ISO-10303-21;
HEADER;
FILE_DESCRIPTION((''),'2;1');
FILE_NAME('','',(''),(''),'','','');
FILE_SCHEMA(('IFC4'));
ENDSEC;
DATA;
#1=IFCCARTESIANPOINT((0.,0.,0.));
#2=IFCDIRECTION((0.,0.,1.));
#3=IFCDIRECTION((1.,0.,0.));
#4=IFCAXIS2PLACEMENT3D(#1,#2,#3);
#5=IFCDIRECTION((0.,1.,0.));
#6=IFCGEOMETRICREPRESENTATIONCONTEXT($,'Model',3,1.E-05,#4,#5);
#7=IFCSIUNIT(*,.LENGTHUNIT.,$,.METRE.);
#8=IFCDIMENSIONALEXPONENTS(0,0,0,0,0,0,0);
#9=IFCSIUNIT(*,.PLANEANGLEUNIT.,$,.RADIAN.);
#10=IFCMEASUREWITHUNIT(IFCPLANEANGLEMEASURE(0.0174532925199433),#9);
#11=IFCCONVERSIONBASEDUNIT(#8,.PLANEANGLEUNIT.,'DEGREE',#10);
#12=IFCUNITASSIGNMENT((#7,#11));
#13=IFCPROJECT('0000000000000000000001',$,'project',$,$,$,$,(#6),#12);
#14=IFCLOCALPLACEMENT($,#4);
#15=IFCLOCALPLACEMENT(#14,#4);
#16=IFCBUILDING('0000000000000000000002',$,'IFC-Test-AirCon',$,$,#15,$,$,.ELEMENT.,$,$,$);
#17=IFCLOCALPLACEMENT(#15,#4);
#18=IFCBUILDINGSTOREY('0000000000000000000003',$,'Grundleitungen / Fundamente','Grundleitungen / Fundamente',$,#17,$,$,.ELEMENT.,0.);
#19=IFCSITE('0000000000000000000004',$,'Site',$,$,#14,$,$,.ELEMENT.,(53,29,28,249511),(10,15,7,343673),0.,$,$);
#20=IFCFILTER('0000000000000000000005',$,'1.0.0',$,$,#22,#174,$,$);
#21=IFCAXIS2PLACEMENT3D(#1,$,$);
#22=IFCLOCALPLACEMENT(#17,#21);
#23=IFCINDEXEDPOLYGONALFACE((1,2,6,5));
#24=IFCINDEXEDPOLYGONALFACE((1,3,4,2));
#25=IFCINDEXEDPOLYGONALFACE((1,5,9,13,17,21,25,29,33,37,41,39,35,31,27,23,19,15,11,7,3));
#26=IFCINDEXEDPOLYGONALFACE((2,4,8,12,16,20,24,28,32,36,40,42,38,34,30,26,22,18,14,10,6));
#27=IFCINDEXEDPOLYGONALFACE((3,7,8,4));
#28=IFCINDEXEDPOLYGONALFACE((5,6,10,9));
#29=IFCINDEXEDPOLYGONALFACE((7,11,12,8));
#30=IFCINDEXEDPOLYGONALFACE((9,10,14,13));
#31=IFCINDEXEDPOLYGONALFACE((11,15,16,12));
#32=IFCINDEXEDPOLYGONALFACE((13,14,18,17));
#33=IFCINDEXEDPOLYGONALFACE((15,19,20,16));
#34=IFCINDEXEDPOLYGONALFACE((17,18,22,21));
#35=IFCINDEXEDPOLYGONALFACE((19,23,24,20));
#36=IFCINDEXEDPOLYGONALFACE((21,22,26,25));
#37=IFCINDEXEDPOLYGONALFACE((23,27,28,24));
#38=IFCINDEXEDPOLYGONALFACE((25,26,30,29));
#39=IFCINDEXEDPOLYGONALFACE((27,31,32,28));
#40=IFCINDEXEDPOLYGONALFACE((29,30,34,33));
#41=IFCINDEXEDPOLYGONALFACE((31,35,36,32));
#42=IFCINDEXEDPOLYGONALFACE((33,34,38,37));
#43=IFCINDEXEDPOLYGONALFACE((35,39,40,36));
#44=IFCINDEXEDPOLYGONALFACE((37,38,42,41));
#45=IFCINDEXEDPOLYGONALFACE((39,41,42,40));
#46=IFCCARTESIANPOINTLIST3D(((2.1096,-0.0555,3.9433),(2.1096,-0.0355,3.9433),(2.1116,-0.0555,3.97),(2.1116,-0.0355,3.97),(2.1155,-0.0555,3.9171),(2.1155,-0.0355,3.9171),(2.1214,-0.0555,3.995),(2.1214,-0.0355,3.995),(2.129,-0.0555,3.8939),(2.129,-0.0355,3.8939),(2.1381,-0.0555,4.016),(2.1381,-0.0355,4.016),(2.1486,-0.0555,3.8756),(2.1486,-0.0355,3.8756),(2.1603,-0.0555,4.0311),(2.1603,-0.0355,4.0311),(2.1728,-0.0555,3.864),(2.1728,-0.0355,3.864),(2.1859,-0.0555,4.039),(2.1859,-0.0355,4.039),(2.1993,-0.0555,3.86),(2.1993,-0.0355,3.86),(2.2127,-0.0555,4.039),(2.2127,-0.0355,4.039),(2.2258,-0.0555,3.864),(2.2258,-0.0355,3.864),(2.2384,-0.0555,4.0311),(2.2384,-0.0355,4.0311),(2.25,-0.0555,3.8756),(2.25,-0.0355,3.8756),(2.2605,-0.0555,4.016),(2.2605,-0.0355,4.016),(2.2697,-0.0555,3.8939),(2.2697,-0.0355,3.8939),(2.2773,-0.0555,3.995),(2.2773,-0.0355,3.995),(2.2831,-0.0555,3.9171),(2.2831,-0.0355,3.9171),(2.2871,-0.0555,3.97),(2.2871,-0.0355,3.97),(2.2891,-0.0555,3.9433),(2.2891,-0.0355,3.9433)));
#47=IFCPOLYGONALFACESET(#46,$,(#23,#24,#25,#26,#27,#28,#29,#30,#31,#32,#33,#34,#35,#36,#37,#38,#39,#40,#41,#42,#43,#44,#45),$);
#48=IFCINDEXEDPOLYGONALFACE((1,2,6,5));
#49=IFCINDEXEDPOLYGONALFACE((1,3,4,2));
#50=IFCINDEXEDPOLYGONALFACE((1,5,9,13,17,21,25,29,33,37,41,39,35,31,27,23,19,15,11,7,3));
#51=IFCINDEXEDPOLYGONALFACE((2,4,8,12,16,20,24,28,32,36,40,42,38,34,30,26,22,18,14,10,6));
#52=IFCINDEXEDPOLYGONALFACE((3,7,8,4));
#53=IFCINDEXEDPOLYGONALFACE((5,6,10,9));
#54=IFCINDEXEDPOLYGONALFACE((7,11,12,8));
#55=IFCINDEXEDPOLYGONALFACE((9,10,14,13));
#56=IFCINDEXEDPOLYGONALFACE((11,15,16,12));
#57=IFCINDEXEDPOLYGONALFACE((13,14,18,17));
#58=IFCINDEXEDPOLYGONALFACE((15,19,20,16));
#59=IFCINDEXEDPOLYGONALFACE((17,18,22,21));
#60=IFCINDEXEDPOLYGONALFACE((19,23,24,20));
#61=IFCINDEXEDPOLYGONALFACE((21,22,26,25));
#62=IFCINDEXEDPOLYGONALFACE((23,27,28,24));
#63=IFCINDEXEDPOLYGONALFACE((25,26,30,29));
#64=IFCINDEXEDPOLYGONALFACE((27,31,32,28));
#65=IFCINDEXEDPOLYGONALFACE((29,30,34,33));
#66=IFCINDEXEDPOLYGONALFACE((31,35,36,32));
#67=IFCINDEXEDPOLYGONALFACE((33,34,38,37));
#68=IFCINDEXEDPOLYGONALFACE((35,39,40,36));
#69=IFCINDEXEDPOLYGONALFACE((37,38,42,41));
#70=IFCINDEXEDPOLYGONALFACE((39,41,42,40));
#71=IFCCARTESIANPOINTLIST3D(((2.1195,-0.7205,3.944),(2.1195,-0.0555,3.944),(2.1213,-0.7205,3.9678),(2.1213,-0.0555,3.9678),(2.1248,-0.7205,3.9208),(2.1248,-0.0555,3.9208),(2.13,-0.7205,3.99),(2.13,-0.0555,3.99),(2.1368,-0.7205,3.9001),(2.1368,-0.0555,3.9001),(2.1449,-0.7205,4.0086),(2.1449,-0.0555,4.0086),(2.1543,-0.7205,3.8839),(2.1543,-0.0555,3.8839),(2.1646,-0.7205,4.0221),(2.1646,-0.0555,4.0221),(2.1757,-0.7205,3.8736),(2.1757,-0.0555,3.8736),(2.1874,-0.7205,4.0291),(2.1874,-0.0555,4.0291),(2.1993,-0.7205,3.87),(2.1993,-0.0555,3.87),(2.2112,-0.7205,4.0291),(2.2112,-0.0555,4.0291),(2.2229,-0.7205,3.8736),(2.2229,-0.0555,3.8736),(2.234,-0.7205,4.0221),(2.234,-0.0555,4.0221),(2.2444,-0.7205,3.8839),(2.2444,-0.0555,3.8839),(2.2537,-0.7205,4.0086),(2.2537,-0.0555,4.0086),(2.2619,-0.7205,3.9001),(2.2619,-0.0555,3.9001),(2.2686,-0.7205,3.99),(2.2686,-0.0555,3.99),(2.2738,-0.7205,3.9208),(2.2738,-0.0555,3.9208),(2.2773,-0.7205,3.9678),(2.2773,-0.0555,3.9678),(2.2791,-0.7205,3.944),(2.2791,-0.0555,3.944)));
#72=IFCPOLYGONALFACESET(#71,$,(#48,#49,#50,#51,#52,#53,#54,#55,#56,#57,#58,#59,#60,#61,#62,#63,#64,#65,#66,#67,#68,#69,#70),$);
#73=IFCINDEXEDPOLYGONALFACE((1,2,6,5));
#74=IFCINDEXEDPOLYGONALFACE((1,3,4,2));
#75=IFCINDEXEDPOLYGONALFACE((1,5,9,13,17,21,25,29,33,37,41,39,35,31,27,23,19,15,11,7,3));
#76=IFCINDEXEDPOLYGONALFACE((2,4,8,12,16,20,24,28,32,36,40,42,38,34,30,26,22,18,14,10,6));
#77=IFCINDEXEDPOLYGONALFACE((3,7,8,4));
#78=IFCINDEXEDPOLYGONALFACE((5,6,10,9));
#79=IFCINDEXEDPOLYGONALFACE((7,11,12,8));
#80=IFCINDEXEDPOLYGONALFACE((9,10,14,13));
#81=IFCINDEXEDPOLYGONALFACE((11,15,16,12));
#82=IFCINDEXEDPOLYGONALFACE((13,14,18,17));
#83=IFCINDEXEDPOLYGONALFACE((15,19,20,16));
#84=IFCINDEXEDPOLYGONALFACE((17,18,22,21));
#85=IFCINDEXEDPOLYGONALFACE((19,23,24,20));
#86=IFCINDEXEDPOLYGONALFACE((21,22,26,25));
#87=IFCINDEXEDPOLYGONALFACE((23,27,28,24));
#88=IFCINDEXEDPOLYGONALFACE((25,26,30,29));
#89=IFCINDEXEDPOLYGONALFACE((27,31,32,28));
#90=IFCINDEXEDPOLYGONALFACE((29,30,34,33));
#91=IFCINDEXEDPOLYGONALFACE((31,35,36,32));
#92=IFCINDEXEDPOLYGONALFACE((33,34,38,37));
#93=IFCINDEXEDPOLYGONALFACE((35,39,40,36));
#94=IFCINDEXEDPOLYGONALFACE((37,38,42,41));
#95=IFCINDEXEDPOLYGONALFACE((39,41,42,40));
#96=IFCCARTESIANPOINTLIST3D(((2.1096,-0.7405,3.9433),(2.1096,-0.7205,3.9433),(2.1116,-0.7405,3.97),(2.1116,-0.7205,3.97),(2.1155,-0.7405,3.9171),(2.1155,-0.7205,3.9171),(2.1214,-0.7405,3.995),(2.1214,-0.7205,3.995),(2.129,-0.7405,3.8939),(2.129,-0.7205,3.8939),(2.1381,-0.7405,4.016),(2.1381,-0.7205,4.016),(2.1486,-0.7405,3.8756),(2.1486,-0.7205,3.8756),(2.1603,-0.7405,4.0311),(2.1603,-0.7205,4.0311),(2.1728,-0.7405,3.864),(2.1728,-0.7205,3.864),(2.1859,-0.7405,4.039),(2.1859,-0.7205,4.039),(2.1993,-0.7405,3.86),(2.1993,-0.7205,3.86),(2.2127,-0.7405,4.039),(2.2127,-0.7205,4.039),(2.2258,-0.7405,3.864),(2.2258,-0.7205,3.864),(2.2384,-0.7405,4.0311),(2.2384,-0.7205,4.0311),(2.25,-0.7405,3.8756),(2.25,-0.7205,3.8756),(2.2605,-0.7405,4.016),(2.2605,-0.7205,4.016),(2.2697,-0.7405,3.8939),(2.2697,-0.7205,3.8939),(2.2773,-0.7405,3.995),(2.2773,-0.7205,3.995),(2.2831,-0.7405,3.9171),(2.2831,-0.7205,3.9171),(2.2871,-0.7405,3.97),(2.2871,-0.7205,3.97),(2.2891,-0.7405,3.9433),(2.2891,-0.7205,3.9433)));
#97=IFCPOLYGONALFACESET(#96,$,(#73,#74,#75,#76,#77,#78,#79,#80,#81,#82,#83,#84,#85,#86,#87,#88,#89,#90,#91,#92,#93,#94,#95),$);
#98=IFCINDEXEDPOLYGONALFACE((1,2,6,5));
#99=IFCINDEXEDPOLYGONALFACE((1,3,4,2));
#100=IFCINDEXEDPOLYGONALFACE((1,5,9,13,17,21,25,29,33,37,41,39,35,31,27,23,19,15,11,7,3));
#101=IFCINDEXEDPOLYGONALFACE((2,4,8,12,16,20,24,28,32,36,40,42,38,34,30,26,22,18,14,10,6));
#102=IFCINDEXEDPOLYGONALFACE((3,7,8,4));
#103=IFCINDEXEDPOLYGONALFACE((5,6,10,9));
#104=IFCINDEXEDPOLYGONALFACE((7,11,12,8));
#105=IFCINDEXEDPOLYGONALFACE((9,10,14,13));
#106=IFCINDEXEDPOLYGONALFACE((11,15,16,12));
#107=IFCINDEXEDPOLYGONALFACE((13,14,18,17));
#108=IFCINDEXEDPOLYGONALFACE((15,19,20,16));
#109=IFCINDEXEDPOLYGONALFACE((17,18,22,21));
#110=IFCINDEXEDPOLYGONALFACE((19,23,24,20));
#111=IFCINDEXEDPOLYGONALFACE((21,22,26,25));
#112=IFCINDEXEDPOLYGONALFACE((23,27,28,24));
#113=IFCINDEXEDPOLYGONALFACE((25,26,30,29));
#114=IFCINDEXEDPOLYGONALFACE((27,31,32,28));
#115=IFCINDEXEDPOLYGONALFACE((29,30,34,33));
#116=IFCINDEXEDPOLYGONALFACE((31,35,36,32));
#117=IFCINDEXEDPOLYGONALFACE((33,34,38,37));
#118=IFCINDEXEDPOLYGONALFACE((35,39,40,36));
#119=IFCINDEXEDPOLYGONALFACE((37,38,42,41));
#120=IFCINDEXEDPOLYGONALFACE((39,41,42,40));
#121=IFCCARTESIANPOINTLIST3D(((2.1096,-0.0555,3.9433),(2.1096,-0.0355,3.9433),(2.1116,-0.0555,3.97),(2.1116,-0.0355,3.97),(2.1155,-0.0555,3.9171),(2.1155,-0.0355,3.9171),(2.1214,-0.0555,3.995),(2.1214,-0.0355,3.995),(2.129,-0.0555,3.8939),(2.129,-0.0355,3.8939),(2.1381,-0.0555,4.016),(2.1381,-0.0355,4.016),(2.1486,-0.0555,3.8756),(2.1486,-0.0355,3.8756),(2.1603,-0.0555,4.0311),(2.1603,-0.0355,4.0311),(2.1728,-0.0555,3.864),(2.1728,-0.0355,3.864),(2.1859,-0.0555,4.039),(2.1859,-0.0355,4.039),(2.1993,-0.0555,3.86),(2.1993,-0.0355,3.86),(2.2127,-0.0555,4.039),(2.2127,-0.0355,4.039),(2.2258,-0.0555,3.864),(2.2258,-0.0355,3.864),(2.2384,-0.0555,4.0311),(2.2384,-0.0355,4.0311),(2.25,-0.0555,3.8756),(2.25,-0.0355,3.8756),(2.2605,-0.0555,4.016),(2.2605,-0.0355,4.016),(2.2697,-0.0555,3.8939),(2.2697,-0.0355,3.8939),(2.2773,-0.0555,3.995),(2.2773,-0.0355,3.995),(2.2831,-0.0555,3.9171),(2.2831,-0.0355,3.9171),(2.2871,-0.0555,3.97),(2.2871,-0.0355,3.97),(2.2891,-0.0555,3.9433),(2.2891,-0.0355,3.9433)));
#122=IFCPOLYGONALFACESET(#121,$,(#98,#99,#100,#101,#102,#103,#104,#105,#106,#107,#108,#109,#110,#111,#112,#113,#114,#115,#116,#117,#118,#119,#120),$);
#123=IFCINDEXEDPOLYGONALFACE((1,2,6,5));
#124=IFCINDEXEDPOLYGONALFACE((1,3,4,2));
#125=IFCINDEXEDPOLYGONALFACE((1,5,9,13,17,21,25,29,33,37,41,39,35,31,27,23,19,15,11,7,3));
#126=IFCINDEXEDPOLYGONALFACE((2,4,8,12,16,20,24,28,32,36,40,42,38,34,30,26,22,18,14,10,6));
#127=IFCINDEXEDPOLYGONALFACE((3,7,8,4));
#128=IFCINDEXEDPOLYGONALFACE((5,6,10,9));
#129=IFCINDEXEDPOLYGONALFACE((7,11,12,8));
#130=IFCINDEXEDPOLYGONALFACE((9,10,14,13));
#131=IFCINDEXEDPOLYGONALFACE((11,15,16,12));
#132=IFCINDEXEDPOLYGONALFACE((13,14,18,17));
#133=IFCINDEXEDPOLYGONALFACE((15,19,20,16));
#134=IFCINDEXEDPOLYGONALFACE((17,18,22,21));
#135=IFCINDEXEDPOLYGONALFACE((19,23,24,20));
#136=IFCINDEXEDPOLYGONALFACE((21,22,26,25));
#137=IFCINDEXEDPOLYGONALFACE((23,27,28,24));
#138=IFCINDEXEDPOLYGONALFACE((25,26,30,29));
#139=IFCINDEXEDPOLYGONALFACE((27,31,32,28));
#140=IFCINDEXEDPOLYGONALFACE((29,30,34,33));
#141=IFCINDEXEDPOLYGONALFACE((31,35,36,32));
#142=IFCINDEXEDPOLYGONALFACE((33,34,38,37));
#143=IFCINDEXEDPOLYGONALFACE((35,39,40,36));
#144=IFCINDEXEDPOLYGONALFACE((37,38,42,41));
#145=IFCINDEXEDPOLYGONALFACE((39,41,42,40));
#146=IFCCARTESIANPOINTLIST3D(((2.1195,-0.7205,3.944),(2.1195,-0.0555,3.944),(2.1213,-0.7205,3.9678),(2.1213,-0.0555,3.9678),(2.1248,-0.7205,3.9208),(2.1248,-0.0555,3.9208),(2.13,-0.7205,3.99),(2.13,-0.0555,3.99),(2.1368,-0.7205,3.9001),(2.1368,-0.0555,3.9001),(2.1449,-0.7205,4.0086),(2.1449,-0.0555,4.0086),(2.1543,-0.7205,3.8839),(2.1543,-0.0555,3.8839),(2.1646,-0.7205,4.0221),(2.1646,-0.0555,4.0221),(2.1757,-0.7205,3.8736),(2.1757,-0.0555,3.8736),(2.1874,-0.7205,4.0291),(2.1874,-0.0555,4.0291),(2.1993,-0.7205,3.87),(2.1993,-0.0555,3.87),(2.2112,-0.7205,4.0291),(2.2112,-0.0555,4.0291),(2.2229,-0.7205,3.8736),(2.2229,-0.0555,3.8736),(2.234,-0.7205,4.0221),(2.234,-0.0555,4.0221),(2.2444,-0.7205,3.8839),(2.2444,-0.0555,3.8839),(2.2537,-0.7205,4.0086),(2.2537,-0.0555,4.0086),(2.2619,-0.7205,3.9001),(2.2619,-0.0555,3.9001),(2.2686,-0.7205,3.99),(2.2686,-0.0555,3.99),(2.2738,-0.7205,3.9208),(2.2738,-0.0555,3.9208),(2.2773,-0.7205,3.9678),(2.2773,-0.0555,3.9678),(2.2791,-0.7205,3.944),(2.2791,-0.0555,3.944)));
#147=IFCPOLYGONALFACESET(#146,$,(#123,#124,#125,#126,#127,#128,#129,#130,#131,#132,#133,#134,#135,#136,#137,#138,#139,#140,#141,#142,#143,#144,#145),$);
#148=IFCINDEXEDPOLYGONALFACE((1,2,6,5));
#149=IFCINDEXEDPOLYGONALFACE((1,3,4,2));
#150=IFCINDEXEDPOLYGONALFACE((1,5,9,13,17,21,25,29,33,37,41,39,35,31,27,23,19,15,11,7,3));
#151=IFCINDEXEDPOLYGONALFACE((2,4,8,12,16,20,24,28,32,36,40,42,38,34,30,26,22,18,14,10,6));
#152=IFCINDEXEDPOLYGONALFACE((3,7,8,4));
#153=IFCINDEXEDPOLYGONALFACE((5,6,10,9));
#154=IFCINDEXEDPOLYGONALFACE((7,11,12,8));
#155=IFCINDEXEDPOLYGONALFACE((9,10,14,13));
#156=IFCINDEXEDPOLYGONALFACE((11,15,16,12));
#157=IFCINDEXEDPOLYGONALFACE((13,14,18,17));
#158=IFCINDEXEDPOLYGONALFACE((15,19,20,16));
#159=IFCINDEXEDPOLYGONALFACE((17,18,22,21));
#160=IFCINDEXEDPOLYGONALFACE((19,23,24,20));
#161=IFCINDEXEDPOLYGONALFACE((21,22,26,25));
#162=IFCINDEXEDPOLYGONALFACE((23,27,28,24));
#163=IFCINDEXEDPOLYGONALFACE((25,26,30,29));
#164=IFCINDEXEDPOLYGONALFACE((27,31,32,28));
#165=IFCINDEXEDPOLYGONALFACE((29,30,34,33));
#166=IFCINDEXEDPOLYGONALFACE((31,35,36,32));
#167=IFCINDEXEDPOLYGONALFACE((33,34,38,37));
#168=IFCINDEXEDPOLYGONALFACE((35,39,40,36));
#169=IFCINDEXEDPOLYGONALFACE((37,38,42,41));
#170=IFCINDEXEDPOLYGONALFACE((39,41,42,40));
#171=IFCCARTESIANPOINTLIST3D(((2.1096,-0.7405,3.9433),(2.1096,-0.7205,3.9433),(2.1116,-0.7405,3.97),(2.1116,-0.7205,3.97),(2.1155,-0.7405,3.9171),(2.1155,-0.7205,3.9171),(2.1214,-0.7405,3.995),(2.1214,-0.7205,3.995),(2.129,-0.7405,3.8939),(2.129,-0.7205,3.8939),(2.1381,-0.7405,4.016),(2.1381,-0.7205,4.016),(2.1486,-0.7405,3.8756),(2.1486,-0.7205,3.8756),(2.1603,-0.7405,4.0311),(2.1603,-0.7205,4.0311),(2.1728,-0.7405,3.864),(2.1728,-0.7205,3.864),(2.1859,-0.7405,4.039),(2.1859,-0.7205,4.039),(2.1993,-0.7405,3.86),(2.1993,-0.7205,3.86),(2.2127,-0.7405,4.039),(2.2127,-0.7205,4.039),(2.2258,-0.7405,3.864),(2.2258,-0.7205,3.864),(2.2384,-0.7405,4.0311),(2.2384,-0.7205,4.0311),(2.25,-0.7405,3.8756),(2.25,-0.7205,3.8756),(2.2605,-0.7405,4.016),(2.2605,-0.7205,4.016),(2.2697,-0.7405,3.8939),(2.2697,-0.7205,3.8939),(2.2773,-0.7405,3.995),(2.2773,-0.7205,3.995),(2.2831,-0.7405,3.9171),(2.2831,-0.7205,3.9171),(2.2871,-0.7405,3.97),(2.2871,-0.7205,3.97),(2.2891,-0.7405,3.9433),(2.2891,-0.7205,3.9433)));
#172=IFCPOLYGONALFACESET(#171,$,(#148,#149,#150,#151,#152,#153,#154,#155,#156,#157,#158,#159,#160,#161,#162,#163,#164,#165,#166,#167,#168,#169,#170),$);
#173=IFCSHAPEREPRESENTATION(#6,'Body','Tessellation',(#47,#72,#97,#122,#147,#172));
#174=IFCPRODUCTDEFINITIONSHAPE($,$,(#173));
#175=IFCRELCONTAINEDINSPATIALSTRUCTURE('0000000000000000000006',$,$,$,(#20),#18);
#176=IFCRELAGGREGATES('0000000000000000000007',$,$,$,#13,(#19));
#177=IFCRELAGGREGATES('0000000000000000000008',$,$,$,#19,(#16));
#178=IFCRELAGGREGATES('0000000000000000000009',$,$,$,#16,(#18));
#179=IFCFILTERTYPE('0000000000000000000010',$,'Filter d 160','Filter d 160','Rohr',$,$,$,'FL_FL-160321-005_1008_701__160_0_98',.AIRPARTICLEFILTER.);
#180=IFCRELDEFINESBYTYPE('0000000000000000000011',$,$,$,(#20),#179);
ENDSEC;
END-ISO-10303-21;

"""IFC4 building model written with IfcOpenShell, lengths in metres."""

from ifc_helpers import new_model, entity, si_unit, converted_unit, direction, frame, origin_with_axes, origin_2d_with_axis, place, context, subcontext, project, spatial, circle, extrude, source, transform, mapped, type_object, element, save


model = new_model("IFC4")

# Units and contexts
model_context = context("Model", 3, precision=1e-05, world=origin_with_axes(), true_north=direction((0.0, 1.0, 0.0)))
body_context = subcontext(model_context, "Body", "Model", "MODEL_VIEW")
ifc_project = project(units=[si_unit("LENGTHUNIT", "METRE"), converted_unit("PLANEANGLEUNIT", "DEGREE", entity("IfcPlaneAngleMeasure", 0.0174532925199433), si_unit("PLANEANGLEUNIT", "RADIAN"), dimensions=[0, 0, 0, 0, 0, 0, 0])], contexts=[model_context])

# Site, building, storey
site_placement = place(None, origin_with_axes())
site = spatial("IfcSite", under=ifc_project, at=site_placement, Name="Site", CompositionType="ELEMENT", RefLatitude=(53, 29, 28, 249511), RefLongitude=(10, 15, 7, 343673), RefElevation=0.0)
building_placement = place(site_placement, origin_with_axes())
building = spatial("IfcBuilding", under=site, at=building_placement, Name="IFC-Test-AirCon", CompositionType="ELEMENT")
storey_placement = place(building_placement, origin_with_axes())
storey = spatial("IfcBuildingStorey", under=building, at=storey_placement, Name="Grundleitungen / Fundamente", Description="Grundleitungen / Fundamente", CompositionType="ELEMENT", Elevation=0.0)

# Filter
filter_type = type_object("IfcFilterType", Name="Filter d 160", Description="Filter d 160", ApplicableOccurrence="Rohr", ElementType="FL_FL-160321-005_1008_701__160_0_98", PredefinedType="AIRPARTICLEFILTER")
shared_shape_1 = source(origin_with_axes(), body_context, "Body", "SweptSolid", [
    extrude(circle(Radius=0.09, at=origin_2d_with_axis()), frame((-0.3525, 0.0, 0.0), z_axis=(1.0, 0.0, 0.0), x_axis=(0.0, 0.0, -1.0)), (0.0, 0.0, 1.0), 0.02),
    extrude(circle(Radius=0.08, at=origin_2d_with_axis()), frame((-0.3325, 0.0, 0.0), z_axis=(1.0, 0.0, 0.0), x_axis=(0.0, 0.0, -1.0)), (0.0, 0.0, 1.0), 0.665),
    extrude(circle(Radius=0.09, at=origin_2d_with_axis()), frame((0.3325, 0.0, 0.0), z_axis=(1.0, 0.0, 0.0), x_axis=(0.0, 0.0, -1.0)), (0.0, 0.0, 1.0), 0.02),
    extrude(circle(Radius=0.09, at=origin_2d_with_axis()), frame((-0.3525, 0.0, 0.0), z_axis=(1.0, 0.0, 0.0), x_axis=(0.0, 0.0, -1.0)), (0.0, 0.0, 1.0), 0.02),
    extrude(circle(Radius=0.08, at=origin_2d_with_axis()), frame((-0.3325, 0.0, 0.0), z_axis=(1.0, 0.0, 0.0), x_axis=(0.0, 0.0, -1.0)), (0.0, 0.0, 1.0), 0.665),
    extrude(circle(Radius=0.09, at=origin_2d_with_axis()), frame((0.3325, 0.0, 0.0), z_axis=(1.0, 0.0, 0.0), x_axis=(0.0, 0.0, -1.0)), (0.0, 0.0, 1.0), 0.02),
])
ifc_filter_placement = place(storey_placement, frame((2.1993, -0.388, 3.95), z_axis=(0.0, 0.0, 1.0), x_axis=(0.0, -1.0, 0.0)))
element("IfcFilter", 1, at=ifc_filter_placement, inside=storey, type_object=filter_type, Name="1.0.0", context=model_context, shape_type="MappedRepresentation", body=[
    mapped(shared_shape_1, transform((0.0, 0.0, 0.0), scale=1.0)),
])

save(model, "model.ifc")
